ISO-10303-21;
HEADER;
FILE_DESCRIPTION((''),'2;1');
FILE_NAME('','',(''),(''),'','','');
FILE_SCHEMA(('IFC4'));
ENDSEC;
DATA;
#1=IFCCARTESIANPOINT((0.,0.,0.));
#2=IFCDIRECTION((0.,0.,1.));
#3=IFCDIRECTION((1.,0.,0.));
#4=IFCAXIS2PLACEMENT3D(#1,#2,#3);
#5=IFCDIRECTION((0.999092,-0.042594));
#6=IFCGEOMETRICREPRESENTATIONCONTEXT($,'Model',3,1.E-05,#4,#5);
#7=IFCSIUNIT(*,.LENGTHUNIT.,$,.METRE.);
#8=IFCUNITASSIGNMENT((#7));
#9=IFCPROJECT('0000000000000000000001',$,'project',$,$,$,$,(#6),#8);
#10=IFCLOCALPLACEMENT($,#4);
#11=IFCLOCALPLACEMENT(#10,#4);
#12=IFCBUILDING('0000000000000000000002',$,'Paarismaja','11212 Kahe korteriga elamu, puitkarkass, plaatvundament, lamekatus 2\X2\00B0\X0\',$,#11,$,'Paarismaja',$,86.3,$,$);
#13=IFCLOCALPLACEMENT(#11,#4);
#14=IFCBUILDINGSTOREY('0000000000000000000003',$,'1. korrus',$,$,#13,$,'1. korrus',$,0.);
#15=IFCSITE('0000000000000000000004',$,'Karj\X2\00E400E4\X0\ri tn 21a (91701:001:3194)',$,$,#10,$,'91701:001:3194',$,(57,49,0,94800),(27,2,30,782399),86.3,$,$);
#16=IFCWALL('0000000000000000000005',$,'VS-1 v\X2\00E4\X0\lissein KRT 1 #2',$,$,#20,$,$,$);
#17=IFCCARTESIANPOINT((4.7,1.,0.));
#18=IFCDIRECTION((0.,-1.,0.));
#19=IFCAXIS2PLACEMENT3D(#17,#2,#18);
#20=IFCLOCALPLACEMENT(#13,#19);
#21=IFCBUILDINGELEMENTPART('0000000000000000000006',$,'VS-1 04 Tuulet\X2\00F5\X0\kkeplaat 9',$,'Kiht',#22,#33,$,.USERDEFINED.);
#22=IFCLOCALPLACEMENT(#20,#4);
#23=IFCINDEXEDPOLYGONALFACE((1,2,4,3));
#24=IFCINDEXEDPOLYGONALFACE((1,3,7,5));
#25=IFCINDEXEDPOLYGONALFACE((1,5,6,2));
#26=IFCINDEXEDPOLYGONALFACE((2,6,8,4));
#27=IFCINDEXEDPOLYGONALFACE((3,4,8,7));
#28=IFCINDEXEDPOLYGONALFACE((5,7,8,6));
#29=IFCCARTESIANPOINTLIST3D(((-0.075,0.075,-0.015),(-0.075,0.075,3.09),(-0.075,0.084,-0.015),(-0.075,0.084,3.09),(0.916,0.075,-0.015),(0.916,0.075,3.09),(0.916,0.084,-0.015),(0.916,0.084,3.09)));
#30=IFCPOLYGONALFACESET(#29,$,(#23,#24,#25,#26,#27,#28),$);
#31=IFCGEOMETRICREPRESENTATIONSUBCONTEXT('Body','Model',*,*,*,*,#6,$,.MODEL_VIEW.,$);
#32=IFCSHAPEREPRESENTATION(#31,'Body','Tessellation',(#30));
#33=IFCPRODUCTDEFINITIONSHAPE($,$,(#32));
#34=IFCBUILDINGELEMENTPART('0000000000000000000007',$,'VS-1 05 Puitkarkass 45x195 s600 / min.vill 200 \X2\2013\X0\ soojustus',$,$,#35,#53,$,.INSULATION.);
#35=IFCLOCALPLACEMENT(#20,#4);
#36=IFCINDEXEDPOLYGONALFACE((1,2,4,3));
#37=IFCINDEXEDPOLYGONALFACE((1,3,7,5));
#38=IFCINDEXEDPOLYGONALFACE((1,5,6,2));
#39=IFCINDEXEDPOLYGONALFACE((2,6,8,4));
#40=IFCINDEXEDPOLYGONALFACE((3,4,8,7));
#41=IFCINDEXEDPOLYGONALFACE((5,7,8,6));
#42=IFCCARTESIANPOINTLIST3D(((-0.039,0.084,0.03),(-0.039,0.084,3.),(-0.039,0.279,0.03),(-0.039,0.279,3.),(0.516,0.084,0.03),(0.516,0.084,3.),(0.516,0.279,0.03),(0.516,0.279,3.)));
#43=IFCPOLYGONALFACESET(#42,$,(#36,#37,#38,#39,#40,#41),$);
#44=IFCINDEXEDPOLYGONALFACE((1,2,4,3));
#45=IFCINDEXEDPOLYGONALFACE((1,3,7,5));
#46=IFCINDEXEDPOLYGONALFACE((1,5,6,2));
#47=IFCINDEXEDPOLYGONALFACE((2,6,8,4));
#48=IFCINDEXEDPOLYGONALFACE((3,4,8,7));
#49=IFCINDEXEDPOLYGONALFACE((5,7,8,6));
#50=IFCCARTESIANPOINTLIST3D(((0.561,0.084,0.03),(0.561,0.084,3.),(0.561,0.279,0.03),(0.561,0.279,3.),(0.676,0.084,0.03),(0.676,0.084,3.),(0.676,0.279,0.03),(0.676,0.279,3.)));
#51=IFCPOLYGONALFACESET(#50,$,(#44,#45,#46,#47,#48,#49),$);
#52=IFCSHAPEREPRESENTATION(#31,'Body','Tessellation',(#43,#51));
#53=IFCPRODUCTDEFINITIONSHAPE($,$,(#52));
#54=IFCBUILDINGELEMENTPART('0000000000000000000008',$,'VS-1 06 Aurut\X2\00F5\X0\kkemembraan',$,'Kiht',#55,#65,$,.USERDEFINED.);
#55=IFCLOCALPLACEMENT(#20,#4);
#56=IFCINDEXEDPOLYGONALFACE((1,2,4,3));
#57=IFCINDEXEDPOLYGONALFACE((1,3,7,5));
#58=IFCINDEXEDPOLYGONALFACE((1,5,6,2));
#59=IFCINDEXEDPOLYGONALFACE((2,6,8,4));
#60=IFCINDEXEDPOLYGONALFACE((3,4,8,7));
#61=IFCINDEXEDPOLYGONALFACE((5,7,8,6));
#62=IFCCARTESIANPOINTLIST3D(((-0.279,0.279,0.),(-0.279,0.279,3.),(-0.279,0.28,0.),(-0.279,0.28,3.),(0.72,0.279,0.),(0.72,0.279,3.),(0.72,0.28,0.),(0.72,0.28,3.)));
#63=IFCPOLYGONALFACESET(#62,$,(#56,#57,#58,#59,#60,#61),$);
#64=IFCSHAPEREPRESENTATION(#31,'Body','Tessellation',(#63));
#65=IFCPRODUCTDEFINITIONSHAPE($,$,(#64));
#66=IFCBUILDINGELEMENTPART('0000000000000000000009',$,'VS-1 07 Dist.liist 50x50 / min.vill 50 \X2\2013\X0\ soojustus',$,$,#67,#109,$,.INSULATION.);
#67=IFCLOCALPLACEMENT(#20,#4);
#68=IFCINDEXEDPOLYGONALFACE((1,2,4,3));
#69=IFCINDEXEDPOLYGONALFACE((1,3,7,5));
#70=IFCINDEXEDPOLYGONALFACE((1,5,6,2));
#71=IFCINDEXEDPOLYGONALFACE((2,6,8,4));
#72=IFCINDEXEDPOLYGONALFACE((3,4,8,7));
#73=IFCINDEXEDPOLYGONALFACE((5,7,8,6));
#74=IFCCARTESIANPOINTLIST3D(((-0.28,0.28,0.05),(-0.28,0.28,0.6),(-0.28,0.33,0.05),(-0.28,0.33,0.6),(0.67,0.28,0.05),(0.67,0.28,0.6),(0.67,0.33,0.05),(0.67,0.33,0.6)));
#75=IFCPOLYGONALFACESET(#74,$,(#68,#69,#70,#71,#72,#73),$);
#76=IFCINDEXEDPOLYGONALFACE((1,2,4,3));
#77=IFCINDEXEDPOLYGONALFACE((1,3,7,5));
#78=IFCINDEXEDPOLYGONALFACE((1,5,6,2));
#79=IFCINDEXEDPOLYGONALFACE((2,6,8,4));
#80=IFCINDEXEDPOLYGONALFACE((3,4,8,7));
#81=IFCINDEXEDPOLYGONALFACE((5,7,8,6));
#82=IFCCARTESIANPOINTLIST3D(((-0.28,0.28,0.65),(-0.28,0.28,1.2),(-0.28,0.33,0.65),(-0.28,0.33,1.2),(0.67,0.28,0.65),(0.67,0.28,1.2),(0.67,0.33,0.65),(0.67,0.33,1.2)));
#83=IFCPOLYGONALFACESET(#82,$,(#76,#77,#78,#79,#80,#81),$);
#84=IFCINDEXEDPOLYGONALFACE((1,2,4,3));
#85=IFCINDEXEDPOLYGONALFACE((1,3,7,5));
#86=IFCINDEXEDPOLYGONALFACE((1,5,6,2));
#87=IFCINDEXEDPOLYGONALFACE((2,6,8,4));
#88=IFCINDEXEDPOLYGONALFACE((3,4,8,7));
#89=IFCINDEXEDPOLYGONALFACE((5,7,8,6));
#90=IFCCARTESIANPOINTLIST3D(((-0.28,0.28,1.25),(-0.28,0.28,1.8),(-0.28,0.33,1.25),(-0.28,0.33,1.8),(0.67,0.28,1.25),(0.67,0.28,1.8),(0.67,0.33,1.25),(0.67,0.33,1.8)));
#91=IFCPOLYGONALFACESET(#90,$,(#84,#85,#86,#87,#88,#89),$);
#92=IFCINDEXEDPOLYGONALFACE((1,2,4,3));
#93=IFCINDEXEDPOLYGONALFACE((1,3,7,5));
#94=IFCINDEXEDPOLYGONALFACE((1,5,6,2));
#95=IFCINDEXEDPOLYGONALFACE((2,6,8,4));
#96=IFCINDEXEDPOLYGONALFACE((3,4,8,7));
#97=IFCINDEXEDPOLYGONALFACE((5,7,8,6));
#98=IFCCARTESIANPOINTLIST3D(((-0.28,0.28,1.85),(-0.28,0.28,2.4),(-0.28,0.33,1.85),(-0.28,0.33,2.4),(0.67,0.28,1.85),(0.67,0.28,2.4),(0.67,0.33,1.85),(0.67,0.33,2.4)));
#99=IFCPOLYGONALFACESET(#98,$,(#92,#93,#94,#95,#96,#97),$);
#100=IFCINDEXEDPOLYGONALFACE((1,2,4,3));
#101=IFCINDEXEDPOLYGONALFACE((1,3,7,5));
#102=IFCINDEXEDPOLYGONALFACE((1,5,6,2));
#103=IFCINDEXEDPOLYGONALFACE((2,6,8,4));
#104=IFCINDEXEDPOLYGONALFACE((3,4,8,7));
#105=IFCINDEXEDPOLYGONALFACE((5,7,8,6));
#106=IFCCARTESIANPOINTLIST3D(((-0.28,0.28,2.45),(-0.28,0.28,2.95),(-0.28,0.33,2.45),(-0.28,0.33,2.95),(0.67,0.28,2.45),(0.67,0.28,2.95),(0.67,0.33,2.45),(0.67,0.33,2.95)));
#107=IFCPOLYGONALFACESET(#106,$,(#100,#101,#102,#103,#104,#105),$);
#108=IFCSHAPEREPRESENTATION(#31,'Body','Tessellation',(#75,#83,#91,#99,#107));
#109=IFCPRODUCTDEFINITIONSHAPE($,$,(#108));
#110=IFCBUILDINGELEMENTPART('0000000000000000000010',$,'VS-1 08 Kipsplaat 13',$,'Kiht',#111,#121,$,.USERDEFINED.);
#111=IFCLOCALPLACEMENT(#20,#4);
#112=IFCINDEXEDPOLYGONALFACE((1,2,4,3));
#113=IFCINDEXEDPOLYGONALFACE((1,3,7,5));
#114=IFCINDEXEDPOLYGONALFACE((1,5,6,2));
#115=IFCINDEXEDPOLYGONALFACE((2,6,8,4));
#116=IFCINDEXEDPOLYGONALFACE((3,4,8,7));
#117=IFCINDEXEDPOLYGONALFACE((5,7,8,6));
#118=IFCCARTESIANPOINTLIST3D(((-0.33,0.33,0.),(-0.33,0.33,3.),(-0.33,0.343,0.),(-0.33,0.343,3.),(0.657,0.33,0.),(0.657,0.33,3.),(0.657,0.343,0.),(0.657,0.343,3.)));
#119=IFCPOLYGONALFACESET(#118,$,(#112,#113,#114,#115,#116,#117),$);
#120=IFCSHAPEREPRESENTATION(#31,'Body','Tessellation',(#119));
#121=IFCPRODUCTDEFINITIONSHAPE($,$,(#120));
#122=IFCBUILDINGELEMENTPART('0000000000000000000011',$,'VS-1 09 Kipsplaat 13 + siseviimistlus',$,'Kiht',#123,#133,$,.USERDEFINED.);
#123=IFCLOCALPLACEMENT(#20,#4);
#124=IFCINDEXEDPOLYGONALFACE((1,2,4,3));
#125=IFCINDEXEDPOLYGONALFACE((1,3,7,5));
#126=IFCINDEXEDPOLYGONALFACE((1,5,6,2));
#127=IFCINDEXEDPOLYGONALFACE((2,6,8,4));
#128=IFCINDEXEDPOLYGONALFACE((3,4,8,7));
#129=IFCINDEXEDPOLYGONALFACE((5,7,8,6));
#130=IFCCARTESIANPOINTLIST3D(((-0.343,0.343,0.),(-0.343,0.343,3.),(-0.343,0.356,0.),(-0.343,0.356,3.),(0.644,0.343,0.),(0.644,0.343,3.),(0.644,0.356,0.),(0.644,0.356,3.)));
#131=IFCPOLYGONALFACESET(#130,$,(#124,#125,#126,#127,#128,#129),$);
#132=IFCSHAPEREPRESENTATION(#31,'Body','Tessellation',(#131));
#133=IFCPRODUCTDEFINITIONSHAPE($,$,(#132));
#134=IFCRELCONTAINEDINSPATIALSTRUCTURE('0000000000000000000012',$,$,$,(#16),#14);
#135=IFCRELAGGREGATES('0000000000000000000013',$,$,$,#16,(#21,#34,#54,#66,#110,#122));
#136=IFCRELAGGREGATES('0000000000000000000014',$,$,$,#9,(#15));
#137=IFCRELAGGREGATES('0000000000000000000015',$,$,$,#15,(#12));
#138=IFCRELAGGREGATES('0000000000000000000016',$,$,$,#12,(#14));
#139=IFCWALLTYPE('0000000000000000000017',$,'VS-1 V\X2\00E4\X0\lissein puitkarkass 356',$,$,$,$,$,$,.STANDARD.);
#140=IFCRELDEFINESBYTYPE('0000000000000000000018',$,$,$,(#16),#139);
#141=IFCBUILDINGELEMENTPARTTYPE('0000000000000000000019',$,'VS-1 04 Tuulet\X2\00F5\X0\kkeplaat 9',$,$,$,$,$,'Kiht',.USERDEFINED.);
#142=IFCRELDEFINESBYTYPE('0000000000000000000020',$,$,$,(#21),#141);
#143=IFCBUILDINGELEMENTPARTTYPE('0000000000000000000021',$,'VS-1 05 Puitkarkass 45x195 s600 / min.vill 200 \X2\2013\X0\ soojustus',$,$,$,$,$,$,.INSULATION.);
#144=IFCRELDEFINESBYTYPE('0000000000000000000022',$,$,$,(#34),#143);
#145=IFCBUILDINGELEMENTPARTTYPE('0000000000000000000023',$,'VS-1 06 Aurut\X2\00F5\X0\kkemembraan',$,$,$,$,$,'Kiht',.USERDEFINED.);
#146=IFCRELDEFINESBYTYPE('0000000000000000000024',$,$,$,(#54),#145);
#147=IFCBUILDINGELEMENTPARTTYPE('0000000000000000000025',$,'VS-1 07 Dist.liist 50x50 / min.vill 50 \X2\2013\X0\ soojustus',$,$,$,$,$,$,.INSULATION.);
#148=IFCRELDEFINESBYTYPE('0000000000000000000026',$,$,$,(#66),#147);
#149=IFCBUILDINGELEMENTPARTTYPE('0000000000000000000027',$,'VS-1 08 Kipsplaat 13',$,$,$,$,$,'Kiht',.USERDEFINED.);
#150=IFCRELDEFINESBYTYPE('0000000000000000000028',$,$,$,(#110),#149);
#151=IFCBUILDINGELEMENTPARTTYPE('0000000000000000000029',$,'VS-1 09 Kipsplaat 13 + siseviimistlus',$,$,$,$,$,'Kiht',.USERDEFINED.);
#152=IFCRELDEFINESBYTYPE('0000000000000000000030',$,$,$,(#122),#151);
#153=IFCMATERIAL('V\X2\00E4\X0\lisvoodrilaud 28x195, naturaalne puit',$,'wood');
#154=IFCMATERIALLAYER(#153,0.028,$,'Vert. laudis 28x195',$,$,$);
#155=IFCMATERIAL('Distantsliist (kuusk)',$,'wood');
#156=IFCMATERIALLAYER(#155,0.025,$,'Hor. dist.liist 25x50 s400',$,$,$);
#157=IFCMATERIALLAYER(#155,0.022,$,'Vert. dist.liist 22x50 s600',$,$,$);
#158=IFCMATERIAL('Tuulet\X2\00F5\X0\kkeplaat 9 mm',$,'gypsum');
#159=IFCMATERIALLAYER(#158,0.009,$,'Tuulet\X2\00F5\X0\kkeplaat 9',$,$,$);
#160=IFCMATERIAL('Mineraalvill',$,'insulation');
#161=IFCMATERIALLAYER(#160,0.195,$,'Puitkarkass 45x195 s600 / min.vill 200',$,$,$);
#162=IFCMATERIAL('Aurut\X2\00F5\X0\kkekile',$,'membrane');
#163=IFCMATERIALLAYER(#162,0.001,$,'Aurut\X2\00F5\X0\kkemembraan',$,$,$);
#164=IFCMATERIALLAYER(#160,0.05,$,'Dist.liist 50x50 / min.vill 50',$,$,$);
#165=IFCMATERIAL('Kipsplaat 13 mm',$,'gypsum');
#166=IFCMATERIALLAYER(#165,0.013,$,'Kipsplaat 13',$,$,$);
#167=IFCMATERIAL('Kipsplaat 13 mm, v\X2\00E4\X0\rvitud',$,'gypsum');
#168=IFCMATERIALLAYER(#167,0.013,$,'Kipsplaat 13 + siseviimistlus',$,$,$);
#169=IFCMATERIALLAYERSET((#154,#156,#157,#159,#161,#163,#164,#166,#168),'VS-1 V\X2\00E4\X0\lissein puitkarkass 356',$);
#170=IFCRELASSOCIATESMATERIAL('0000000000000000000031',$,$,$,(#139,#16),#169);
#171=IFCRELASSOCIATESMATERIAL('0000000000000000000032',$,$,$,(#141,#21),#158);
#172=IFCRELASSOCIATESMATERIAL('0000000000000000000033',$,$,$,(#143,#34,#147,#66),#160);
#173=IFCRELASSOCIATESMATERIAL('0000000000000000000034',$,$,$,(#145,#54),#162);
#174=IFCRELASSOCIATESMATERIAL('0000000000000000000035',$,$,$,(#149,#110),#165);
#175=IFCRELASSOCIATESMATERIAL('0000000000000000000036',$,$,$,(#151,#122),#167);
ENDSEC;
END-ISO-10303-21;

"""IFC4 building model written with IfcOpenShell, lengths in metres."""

from ifc_helpers import new_model, si_unit, direction, frame, origin_with_axes, place, context, subcontext, project, spatial, indexed_curve, outline, extrude, material, layer, layer_set, layer_usage, type_object, element, aggregate, save


model = new_model("IFC4")

# Units and contexts
model_context = context("Model", 3, precision=1e-05, world=origin_with_axes(), true_north=direction((0.999092, -0.042594)))
body_context = subcontext(model_context, "Body", "Model", "MODEL_VIEW")
ifc_project = project(units=[si_unit("LENGTHUNIT", "METRE")], contexts=[model_context])

# Site, building, storey
site_placement = place(None, origin_with_axes())
site = spatial("IfcSite", under=ifc_project, at=site_placement, Name="Karjääri tn 21a (91701:001:3194)", LongName="91701:001:3194", RefLatitude=(57, 49, 0, 94800), RefLongitude=(27, 2, 30, 782399), RefElevation=86.3)
building_placement = place(site_placement, origin_with_axes())
building = spatial("IfcBuilding", under=site, at=building_placement, Name="Paarismaja", Description="11212 Kahe korteriga elamu, puitkarkass, plaatvundament, lamekatus 2°", LongName="Paarismaja", ElevationOfRefHeight=86.3)
storey_placement = place(building_placement, origin_with_axes())
storey = spatial("IfcBuildingStorey", under=building, at=storey_placement, Name="1. korrus", LongName="1. korrus", Elevation=0.0)

# Wall
ifc_material_1 = material(Name="Välisvoodrilaud 28x195, naturaalne puit", Category="wood")
ifc_layer_1 = layer(ifc_material_1, 0.028, Name="Vert. laudis 28x195")
ifc_material_2 = material(Name="Distantsliist (kuusk)", Category="wood")
ifc_layer_2 = layer(ifc_material_2, 0.025, Name="Hor. dist.liist 25x50 s400")
ifc_layer_3 = layer(ifc_material_2, 0.022, Name="Vert. dist.liist 22x50 s600")
ifc_material_3 = material(Name="Tuuletõkkeplaat 9 mm", Category="gypsum")
ifc_layer_4 = layer(ifc_material_3, 0.009, Name="Tuuletõkkeplaat 9")
ifc_material_4 = material(Name="Mineraalvill", Category="insulation")
ifc_layer_5 = layer(ifc_material_4, 0.195, Name="Puitkarkass 45x195 s600 / min.vill 200")
ifc_material_5 = material(Name="Aurutõkkekile", Category="membrane")
ifc_layer_6 = layer(ifc_material_5, 0.001, Name="Aurutõkkemembraan")
ifc_layer_7 = layer(ifc_material_4, 0.05, Name="Dist.liist 50x50 / min.vill 50")
ifc_material_6 = material(Name="Kipsplaat 13 mm", Category="gypsum")
ifc_layer_8 = layer(ifc_material_6, 0.013, Name="Kipsplaat 13")
ifc_material_7 = material(Name="Kipsplaat 13 mm, värvitud", Category="gypsum")
ifc_layer_9 = layer(ifc_material_7, 0.013, Name="Kipsplaat 13 + siseviimistlus")
ifc_layer_set_1 = layer_set([ifc_layer_1, ifc_layer_2, ifc_layer_3, ifc_layer_4, ifc_layer_5, ifc_layer_6, ifc_layer_7, ifc_layer_8, ifc_layer_9], Name="VS-1 Välissein puitkarkass 356")
ifc_layer_usage_1 = layer_usage(ifc_layer_set_1, "AXIS2", "POSITIVE", 0.0)
wall_type = type_object("IfcWallType", Name="VS-1 Välissein puitkarkass 356", PredefinedType="STANDARD", material=ifc_layer_set_1)
wall_placement = place(storey_placement, frame((4.7, 1.0, 0.0), z_axis=(0.0, 0.0, 1.0), x_axis=(0.0, -1.0, 0.0)))
wall = element("IfcWall", 1, at=wall_placement, inside=storey, type_object=wall_type, material=ifc_layer_usage_1, Name="VS-1 välissein KRT 1 #2")

# Building element parts
building_element_part_type_1 = type_object("IfcBuildingElementPartType", Name="VS-1 04 Tuuletõkkeplaat 9", ElementType="Kiht", PredefinedType="USERDEFINED", material=ifc_material_3)
building_element_part_1_placement = place(wall_placement, origin_with_axes())
building_element_part_1 = element("IfcBuildingElementPart", 2, at=building_element_part_1_placement, type_object=building_element_part_type_1, material=ifc_material_3, Name="VS-1 04 Tuuletõkkeplaat 9", ObjectType="Kiht", PredefinedType="USERDEFINED", context=body_context, shape_type="SweptSolid", body=[
    extrude(outline(indexed_curve([(0.916, -0.015), (0.916, 3.09), (-0.075, 3.09), (-0.075, -0.015), (0.916, -0.015)], self_intersect=False)), frame((0.0, 0.084, 0.0), z_axis=(0.0, -1.0, 0.0), x_axis=(1.0, 0.0, 0.0)), (0.0, 0.0, 1.0), 0.009),
])
building_element_part_type_2 = type_object("IfcBuildingElementPartType", Name="VS-1 05 Puitkarkass 45x195 s600 / min.vill 200 – soojustus", PredefinedType="INSULATION", material=ifc_material_4)
building_element_part_2_placement = place(wall_placement, origin_with_axes())
building_element_part_2 = element("IfcBuildingElementPart", 3, at=building_element_part_2_placement, type_object=building_element_part_type_2, material=ifc_material_4, Name="VS-1 05 Puitkarkass 45x195 s600 / min.vill 200 – soojustus", PredefinedType="INSULATION", context=body_context, shape_type="SweptSolid", body=[
    extrude(outline(indexed_curve([(-0.039, 0.03), (-0.039, 3.0), (0.516, 3.0), (0.516, 0.03), (-0.039, 0.03)], self_intersect=False)), frame((0.0, 0.279, 0.0), z_axis=(0.0, -1.0, 0.0), x_axis=(1.0, 0.0, 0.0)), (0.0, 0.0, 1.0), 0.195),
    extrude(outline(indexed_curve([(0.676, 0.03), (0.561, 0.03), (0.561, 3.0), (0.676, 3.0), (0.676, 0.03)], self_intersect=False)), frame((0.0, 0.279, 0.0), z_axis=(0.0, -1.0, 0.0), x_axis=(1.0, 0.0, 0.0)), (0.0, 0.0, 1.0), 0.195),
])
building_element_part_type_3 = type_object("IfcBuildingElementPartType", Name="VS-1 06 Aurutõkkemembraan", ElementType="Kiht", PredefinedType="USERDEFINED", material=ifc_material_5)
building_element_part_3_placement = place(wall_placement, origin_with_axes())
building_element_part_3 = element("IfcBuildingElementPart", 4, at=building_element_part_3_placement, type_object=building_element_part_type_3, material=ifc_material_5, Name="VS-1 06 Aurutõkkemembraan", ObjectType="Kiht", PredefinedType="USERDEFINED", context=body_context, shape_type="SweptSolid", body=[
    extrude(outline(indexed_curve([(0.72, 0.0), (0.72, 3.0), (-0.279, 3.0), (-0.279, 0.0), (0.72, 0.0)], self_intersect=False)), frame((0.0, 0.28, 0.0), z_axis=(0.0, -1.0, 0.0), x_axis=(1.0, 0.0, 0.0)), (0.0, 0.0, 1.0), 0.001),
])
building_element_part_type_4 = type_object("IfcBuildingElementPartType", Name="VS-1 07 Dist.liist 50x50 / min.vill 50 – soojustus", PredefinedType="INSULATION", material=ifc_material_4)
building_element_part_4_placement = place(wall_placement, origin_with_axes())
building_element_part_4 = element("IfcBuildingElementPart", 5, at=building_element_part_4_placement, type_object=building_element_part_type_4, material=ifc_material_4, Name="VS-1 07 Dist.liist 50x50 / min.vill 50 – soojustus", PredefinedType="INSULATION", context=body_context, shape_type="SweptSolid", body=[
    extrude(outline(indexed_curve([(0.67, 0.05), (-0.28, 0.05), (-0.28, 0.6), (0.67, 0.6), (0.67, 0.05)], self_intersect=False)), frame((0.0, 0.33, 0.0), z_axis=(0.0, -1.0, 0.0), x_axis=(1.0, 0.0, 0.0)), (0.0, 0.0, 1.0), 0.05),
    extrude(outline(indexed_curve([(0.67, 0.65), (-0.28, 0.65), (-0.28, 1.2), (0.67, 1.2), (0.67, 0.65)], self_intersect=False)), frame((0.0, 0.33, 0.0), z_axis=(0.0, -1.0, 0.0), x_axis=(1.0, 0.0, 0.0)), (0.0, 0.0, 1.0), 0.05),
    extrude(outline(indexed_curve([(0.67, 1.25), (-0.28, 1.25), (-0.28, 1.8), (0.67, 1.8), (0.67, 1.25)], self_intersect=False)), frame((0.0, 0.33, 0.0), z_axis=(0.0, -1.0, 0.0), x_axis=(1.0, 0.0, 0.0)), (0.0, 0.0, 1.0), 0.05),
    extrude(outline(indexed_curve([(0.67, 1.85), (-0.28, 1.85), (-0.28, 2.4), (0.67, 2.4), (0.67, 1.85)], self_intersect=False)), frame((0.0, 0.33, 0.0), z_axis=(0.0, -1.0, 0.0), x_axis=(1.0, 0.0, 0.0)), (0.0, 0.0, 1.0), 0.05),
    extrude(outline(indexed_curve([(0.67, 2.45), (-0.28, 2.45), (-0.28, 2.95), (0.67, 2.95), (0.67, 2.45)], self_intersect=False)), frame((0.0, 0.33, 0.0), z_axis=(0.0, -1.0, 0.0), x_axis=(1.0, 0.0, 0.0)), (0.0, 0.0, 1.0), 0.05),
])
building_element_part_type_5 = type_object("IfcBuildingElementPartType", Name="VS-1 08 Kipsplaat 13", ElementType="Kiht", PredefinedType="USERDEFINED", material=ifc_material_6)
building_element_part_5_placement = place(wall_placement, origin_with_axes())
building_element_part_5 = element("IfcBuildingElementPart", 6, at=building_element_part_5_placement, type_object=building_element_part_type_5, material=ifc_material_6, Name="VS-1 08 Kipsplaat 13", ObjectType="Kiht", PredefinedType="USERDEFINED", context=body_context, shape_type="SweptSolid", body=[
    extrude(outline(indexed_curve([(0.657, 0.0), (0.657, 3.0), (-0.33, 3.0), (-0.33, 0.0), (0.657, 0.0)], self_intersect=False)), frame((0.0, 0.343, 0.0), z_axis=(0.0, -1.0, 0.0), x_axis=(1.0, 0.0, 0.0)), (0.0, 0.0, 1.0), 0.013),
])
building_element_part_type_6 = type_object("IfcBuildingElementPartType", Name="VS-1 09 Kipsplaat 13 + siseviimistlus", ElementType="Kiht", PredefinedType="USERDEFINED", material=ifc_material_7)
building_element_part_6_placement = place(wall_placement, origin_with_axes())
building_element_part_6 = element("IfcBuildingElementPart", 7, at=building_element_part_6_placement, type_object=building_element_part_type_6, material=ifc_material_7, Name="VS-1 09 Kipsplaat 13 + siseviimistlus", ObjectType="Kiht", PredefinedType="USERDEFINED", context=body_context, shape_type="SweptSolid", body=[
    extrude(outline(indexed_curve([(0.644, 0.0), (0.644, 3.0), (-0.343, 3.0), (-0.343, 0.0), (0.644, 0.0)], self_intersect=False)), frame((0.0, 0.356, 0.0), z_axis=(0.0, -1.0, 0.0), x_axis=(1.0, 0.0, 0.0)), (0.0, 0.0, 1.0), 0.013),
])
aggregate(wall, [building_element_part_1, building_element_part_2, building_element_part_3, building_element_part_4, building_element_part_5, building_element_part_6])

save(model, "model.ifc")
